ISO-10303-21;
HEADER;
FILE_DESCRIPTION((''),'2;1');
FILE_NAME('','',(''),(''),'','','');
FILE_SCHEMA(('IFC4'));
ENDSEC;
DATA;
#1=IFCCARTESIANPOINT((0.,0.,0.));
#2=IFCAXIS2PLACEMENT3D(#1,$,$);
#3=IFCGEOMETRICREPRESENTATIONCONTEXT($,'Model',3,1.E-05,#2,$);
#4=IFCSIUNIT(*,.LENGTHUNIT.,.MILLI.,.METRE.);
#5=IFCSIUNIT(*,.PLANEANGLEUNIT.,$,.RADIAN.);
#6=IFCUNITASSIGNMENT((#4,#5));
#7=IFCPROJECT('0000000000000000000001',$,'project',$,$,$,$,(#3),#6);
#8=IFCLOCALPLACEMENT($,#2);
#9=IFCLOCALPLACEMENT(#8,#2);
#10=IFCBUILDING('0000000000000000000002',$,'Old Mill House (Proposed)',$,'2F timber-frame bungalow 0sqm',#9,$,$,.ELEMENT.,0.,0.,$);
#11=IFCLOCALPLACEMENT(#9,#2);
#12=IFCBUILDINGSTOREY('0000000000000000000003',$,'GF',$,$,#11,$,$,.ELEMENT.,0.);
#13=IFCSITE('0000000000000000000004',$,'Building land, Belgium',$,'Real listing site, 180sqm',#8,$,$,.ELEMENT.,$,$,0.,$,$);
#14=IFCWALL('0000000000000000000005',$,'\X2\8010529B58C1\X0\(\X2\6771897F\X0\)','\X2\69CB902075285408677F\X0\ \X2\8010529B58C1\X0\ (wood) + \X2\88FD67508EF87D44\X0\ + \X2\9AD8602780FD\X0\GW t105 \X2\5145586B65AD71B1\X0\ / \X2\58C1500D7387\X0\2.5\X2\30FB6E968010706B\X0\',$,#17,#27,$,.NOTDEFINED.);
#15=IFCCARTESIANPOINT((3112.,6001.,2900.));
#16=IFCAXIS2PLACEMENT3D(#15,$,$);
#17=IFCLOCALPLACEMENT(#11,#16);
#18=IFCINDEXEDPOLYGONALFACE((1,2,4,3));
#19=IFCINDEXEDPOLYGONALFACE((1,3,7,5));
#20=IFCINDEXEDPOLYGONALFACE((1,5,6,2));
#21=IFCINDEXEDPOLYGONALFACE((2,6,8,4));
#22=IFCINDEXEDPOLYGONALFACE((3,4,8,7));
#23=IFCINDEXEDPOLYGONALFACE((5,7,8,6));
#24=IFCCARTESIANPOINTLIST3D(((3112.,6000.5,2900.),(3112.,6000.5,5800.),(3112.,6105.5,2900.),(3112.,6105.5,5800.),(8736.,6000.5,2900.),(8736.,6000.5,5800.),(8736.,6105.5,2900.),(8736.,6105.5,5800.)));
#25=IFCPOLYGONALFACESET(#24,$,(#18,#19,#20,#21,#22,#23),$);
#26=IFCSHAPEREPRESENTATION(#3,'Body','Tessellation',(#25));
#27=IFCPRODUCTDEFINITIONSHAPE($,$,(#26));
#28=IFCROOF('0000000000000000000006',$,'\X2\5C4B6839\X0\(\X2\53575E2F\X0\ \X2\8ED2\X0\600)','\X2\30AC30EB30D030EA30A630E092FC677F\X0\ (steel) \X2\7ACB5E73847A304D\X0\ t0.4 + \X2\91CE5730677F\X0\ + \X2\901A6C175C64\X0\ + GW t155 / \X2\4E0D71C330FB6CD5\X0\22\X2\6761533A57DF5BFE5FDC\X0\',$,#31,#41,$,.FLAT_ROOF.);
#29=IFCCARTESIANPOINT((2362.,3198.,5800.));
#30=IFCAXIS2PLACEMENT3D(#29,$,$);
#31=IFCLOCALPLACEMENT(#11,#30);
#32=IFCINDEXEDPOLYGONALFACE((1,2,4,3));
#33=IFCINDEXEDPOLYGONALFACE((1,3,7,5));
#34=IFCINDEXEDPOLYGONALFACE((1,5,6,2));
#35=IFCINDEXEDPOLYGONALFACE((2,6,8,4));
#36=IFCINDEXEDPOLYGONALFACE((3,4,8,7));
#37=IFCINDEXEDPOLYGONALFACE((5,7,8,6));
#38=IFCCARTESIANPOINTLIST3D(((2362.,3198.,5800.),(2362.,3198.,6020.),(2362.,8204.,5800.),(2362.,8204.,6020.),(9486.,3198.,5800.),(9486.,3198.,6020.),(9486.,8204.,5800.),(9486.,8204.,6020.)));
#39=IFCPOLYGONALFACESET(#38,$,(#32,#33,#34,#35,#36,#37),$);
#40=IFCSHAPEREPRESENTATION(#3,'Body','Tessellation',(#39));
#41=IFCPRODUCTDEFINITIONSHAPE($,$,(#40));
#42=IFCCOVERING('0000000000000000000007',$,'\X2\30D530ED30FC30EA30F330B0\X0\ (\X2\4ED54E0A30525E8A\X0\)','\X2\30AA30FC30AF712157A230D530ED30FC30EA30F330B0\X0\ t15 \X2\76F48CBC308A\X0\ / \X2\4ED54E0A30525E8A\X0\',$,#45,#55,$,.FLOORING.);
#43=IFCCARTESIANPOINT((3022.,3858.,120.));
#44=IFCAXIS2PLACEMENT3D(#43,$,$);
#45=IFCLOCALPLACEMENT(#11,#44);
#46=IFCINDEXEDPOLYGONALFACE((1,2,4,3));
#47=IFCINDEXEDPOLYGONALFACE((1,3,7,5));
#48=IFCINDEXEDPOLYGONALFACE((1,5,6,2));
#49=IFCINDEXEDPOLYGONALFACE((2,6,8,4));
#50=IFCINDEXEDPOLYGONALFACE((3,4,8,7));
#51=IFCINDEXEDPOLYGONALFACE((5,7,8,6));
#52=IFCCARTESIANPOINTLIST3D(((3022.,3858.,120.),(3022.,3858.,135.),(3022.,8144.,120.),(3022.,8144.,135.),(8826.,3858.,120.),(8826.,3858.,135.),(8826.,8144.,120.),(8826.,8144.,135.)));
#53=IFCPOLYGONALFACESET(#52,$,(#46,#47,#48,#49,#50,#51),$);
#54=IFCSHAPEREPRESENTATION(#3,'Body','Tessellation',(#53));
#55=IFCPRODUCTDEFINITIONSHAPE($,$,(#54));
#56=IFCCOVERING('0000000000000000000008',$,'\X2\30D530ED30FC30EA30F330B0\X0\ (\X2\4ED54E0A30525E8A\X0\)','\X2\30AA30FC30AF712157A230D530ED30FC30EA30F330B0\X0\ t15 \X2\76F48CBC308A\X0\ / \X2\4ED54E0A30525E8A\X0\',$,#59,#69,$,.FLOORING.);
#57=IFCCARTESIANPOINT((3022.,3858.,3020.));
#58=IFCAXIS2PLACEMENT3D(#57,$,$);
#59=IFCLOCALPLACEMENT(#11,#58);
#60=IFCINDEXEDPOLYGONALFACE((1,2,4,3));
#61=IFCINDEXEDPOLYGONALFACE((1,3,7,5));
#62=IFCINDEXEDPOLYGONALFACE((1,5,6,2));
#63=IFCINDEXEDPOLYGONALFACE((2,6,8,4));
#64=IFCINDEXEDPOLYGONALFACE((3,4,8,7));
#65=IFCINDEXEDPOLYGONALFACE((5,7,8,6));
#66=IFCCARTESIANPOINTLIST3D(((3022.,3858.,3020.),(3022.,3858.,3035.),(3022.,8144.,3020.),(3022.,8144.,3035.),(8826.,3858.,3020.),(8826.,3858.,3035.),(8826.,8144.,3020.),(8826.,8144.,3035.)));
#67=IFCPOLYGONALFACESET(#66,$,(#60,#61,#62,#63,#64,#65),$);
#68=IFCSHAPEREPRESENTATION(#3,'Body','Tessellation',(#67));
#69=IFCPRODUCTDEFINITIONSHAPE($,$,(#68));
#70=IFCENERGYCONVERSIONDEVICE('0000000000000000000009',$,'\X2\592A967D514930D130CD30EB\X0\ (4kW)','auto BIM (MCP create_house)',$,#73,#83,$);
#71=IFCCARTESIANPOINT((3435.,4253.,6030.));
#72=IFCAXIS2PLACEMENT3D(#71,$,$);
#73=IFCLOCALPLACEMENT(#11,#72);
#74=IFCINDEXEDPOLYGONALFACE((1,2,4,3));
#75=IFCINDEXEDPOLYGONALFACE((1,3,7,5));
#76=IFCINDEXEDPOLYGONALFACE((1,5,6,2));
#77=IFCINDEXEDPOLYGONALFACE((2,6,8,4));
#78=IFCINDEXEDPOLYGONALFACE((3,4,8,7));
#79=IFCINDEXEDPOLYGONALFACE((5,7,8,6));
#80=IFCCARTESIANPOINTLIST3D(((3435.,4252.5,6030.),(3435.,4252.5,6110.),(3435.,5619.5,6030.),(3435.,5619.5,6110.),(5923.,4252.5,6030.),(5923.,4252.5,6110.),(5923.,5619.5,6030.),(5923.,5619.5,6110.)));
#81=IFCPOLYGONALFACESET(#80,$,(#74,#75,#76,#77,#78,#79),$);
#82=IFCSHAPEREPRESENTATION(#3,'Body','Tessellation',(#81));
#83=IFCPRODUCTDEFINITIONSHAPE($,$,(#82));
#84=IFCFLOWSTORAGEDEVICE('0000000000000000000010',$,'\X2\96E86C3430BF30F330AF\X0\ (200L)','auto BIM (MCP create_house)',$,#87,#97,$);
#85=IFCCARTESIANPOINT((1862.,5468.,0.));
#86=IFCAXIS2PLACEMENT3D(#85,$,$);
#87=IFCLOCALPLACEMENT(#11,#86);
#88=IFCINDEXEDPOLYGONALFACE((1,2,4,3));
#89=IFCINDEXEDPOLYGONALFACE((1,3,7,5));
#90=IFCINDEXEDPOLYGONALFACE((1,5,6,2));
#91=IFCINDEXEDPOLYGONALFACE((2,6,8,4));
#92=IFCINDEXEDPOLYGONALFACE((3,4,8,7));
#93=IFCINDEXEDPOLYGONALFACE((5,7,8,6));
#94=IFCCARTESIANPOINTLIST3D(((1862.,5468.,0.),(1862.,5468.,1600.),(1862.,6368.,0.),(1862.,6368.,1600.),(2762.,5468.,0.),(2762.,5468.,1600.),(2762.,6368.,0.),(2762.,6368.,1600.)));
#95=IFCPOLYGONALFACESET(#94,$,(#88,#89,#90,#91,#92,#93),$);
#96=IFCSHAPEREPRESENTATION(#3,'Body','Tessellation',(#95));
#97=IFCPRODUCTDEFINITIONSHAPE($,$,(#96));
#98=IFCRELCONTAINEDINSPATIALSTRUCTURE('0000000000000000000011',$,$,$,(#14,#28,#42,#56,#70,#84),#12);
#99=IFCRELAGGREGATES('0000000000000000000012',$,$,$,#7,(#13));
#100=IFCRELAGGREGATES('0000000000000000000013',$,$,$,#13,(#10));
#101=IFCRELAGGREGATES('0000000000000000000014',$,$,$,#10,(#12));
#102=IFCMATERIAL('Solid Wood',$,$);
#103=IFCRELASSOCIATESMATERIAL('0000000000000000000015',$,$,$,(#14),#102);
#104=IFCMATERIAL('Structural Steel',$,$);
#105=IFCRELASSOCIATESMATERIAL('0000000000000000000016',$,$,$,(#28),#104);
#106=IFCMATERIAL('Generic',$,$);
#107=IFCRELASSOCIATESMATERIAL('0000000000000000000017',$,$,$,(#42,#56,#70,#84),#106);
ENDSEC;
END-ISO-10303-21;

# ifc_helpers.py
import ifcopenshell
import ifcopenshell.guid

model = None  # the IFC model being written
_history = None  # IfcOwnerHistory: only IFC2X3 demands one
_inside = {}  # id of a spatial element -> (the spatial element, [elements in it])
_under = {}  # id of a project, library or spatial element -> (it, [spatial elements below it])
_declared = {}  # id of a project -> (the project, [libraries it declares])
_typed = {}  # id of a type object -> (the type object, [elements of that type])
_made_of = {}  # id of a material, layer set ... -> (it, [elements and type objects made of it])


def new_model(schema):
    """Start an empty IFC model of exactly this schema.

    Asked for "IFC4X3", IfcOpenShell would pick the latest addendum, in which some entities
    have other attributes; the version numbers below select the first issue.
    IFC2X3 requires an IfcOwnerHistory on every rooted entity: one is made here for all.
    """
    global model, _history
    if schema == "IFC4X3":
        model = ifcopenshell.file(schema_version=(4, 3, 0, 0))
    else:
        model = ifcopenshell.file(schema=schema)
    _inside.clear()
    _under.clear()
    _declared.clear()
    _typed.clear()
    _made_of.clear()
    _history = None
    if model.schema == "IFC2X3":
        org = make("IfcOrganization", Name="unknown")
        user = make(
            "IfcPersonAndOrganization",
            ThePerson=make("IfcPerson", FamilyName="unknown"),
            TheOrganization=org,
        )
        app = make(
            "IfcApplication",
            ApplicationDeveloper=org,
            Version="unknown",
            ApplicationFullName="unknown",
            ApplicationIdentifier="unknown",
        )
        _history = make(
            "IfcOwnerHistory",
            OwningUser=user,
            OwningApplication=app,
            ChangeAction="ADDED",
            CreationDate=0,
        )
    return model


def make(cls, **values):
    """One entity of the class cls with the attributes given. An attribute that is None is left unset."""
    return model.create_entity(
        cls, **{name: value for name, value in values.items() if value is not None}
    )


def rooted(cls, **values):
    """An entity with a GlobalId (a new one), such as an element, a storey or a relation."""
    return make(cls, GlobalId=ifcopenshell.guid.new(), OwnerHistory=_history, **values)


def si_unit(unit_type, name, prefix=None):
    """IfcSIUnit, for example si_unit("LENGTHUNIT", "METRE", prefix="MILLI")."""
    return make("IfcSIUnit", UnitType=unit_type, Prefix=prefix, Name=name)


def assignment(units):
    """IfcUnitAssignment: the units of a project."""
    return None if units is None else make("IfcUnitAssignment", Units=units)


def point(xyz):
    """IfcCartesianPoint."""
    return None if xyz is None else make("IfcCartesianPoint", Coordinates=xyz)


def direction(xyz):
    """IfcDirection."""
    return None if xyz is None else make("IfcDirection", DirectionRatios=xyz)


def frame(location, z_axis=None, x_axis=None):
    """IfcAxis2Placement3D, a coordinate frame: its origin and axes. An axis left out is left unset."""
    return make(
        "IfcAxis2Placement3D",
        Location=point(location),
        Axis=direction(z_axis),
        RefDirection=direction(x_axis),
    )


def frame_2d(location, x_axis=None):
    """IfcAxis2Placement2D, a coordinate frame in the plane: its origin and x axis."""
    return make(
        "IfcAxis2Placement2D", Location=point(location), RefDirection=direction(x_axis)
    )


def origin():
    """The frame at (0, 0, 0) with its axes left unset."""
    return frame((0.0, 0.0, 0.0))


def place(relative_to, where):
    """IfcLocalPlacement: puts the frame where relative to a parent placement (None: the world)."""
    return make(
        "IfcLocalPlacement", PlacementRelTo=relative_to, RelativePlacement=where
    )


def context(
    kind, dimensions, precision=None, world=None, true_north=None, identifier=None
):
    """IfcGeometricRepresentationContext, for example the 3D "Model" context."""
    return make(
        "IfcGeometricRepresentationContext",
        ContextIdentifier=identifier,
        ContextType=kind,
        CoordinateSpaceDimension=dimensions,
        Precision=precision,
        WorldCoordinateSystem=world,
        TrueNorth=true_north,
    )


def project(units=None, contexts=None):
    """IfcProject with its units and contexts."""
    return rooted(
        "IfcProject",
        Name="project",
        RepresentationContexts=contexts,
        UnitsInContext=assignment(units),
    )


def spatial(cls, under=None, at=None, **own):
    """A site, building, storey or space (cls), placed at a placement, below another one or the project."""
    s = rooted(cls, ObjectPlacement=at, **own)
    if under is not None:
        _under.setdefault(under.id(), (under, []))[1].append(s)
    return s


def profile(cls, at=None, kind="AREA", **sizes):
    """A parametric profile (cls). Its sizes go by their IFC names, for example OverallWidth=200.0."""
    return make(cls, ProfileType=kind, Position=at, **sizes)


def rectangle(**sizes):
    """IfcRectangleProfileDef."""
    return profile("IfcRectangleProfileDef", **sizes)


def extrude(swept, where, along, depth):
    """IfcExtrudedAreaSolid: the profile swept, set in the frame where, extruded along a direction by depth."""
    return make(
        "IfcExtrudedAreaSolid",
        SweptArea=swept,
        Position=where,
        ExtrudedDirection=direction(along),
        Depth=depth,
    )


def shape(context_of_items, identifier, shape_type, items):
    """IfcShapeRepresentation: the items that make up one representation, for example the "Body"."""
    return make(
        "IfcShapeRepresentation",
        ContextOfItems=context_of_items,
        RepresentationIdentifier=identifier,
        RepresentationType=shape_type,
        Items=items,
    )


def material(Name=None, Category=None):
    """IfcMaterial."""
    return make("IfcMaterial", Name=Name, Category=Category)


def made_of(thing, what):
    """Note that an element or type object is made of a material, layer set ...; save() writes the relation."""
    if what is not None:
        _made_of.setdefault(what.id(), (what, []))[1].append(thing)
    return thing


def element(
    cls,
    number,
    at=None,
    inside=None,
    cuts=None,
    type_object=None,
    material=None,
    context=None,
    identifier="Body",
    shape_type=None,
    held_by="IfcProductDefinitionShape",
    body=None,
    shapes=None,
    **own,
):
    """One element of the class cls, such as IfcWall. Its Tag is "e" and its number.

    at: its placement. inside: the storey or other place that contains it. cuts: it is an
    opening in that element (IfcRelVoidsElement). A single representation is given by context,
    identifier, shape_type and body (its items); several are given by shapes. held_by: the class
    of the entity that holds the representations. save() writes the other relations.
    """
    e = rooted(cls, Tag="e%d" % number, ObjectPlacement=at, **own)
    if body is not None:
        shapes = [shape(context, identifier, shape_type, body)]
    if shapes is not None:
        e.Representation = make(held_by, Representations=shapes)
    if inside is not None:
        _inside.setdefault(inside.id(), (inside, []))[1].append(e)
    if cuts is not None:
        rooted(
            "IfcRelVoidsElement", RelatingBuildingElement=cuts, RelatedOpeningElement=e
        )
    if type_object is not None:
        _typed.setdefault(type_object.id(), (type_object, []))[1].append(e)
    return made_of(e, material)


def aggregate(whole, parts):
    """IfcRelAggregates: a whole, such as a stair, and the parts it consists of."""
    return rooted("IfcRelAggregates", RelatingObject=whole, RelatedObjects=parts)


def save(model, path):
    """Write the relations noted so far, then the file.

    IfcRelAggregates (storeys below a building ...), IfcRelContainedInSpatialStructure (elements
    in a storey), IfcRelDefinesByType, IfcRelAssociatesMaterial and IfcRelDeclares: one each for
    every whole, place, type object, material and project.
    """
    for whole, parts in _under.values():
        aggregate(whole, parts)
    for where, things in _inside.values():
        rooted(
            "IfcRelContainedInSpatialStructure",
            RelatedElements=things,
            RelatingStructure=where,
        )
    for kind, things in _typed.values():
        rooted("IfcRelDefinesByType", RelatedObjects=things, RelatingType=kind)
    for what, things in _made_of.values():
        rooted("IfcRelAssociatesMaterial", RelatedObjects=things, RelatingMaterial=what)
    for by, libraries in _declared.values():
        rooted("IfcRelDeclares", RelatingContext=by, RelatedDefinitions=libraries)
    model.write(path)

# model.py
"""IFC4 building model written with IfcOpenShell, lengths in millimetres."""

from ifc_helpers import new_model, si_unit, frame, frame_2d, origin, place, context, project, spatial, rectangle, extrude, material, element, save


model = new_model("IFC4")

# Units and contexts
model_context = context("Model", 3, precision=1e-05, world=origin())
ifc_project = project(units=[si_unit("LENGTHUNIT", "METRE", prefix="MILLI"), si_unit("PLANEANGLEUNIT", "RADIAN")], contexts=[model_context])

# Site, building, storey
site_placement = place(None, origin())
site = spatial("IfcSite", under=ifc_project, at=site_placement, Name="Building land, Belgium", ObjectType="Real listing site, 180sqm", CompositionType="ELEMENT", RefElevation=0.0)
building_placement = place(site_placement, origin())
building = spatial("IfcBuilding", under=site, at=building_placement, Name="Old Mill House (Proposed)", ObjectType="2F timber-frame bungalow 0sqm", CompositionType="ELEMENT", ElevationOfRefHeight=0.0, ElevationOfTerrain=0.0)
storey_placement = place(building_placement, origin())
storey = spatial("IfcBuildingStorey", under=building, at=storey_placement, Name="GF", CompositionType="ELEMENT", Elevation=0.0)

# Shared definitions
ifc_material_1 = material(Name="Solid Wood")

# Wall
wall_1_placement = place(storey_placement, frame((3112.0, 6001.0, 2900.0)))
element("IfcWall", 1, at=wall_1_placement, inside=storey, material=ifc_material_1, Name="耐力壁(東西)", Description="構造用合板 耐力壁 (wood) + 製材軸組 + 高性能GW t105 充填断熱 / 壁倍率2.5・準耐火", PredefinedType="NOTDEFINED", context=model_context, shape_type="SweptSolid", body=[
    extrude(rectangle(XDim=5624.0, YDim=105.0, at=frame_2d((2812.0, 52.0))), frame((3112.0, 6001.0, 2900.0)), (0.0, 0.0, 1.0), 2900.0),
])

# Roof
ifc_material_2 = material(Name="Structural Steel")
for number, where, name in (
    (2, (2362.0, 3198.0, 5800.0), "屋根(南帯 軒600)"),
):
    element("IfcRoof", number, at=place(storey_placement, frame(where)), inside=storey, material=ifc_material_2, Name=name, Description="ガルバリウム鋼板 (steel) 立平葺き t0.4 + 野地板 + 通気層 + GW t155 / 不燃・法22条区域対応", PredefinedType="FLAT_ROOF", context=model_context, shape_type="SweptSolid", body=[
        extrude(rectangle(XDim=7124.0, YDim=5006.0, at=frame_2d((3562.0, 2503.0))), frame((2362.0, 3198.0, 5800.0)), (0.0, 0.0, 1.0), 220.0),
    ])

# Coverings
ifc_material_3 = material(Name="Generic")
covering_1_placement = place(storey_placement, frame((3022.0, 3858.0, 120.0)))
element("IfcCovering", 3, at=covering_1_placement, inside=storey, material=ifc_material_3, Name="フローリング (仕上げ床)", Description="オーク無垢フローリング t15 直貼り / 仕上げ床", PredefinedType="FLOORING", context=model_context, shape_type="SweptSolid", body=[
    extrude(rectangle(XDim=5804.0, YDim=4286.0, at=frame_2d((2902.0, 2143.0))), frame((3022.0, 3858.0, 120.0)), (0.0, 0.0, 1.0), 15.0),
])
covering_2_placement = place(storey_placement, frame((3022.0, 3858.0, 3020.0)))
element("IfcCovering", 4, at=covering_2_placement, inside=storey, material=ifc_material_3, Name="フローリング (仕上げ床)", Description="オーク無垢フローリング t15 直貼り / 仕上げ床", PredefinedType="FLOORING", context=model_context, shape_type="SweptSolid", body=[
    extrude(rectangle(XDim=5804.0, YDim=4286.0, at=frame_2d((2902.0, 2143.0))), frame((3022.0, 3858.0, 3020.0)), (0.0, 0.0, 1.0), 15.0),
])

# Energy conversion device
energy_conversion_device_placement = place(storey_placement, frame((3435.0, 4253.0, 6030.0)))
element("IfcEnergyConversionDevice", 5, at=energy_conversion_device_placement, inside=storey, material=ifc_material_3, Name="太陽光パネル (4kW)", Description="auto BIM (MCP create_house)", context=model_context, shape_type="SweptSolid", body=[
    extrude(rectangle(XDim=2488.0, YDim=1367.0, at=frame_2d((1244.0, 683.0))), frame((3435.0, 4253.0, 6030.0)), (0.0, 0.0, 1.0), 80.0),
])

# Flow storage device
flow_storage_device_placement = place(storey_placement, frame((1862.0, 5468.0, 0.0)))
element("IfcFlowStorageDevice", 6, at=flow_storage_device_placement, inside=storey, material=ifc_material_3, Name="雨水タンク (200L)", Description="auto BIM (MCP create_house)", context=model_context, shape_type="SweptSolid", body=[
    extrude(rectangle(XDim=900.0, YDim=900.0, at=frame_2d((450.0, 450.0))), frame((1862.0, 5468.0, 0.0)), (0.0, 0.0, 1.0), 1600.0),
])

save(model, "model.ifc")
